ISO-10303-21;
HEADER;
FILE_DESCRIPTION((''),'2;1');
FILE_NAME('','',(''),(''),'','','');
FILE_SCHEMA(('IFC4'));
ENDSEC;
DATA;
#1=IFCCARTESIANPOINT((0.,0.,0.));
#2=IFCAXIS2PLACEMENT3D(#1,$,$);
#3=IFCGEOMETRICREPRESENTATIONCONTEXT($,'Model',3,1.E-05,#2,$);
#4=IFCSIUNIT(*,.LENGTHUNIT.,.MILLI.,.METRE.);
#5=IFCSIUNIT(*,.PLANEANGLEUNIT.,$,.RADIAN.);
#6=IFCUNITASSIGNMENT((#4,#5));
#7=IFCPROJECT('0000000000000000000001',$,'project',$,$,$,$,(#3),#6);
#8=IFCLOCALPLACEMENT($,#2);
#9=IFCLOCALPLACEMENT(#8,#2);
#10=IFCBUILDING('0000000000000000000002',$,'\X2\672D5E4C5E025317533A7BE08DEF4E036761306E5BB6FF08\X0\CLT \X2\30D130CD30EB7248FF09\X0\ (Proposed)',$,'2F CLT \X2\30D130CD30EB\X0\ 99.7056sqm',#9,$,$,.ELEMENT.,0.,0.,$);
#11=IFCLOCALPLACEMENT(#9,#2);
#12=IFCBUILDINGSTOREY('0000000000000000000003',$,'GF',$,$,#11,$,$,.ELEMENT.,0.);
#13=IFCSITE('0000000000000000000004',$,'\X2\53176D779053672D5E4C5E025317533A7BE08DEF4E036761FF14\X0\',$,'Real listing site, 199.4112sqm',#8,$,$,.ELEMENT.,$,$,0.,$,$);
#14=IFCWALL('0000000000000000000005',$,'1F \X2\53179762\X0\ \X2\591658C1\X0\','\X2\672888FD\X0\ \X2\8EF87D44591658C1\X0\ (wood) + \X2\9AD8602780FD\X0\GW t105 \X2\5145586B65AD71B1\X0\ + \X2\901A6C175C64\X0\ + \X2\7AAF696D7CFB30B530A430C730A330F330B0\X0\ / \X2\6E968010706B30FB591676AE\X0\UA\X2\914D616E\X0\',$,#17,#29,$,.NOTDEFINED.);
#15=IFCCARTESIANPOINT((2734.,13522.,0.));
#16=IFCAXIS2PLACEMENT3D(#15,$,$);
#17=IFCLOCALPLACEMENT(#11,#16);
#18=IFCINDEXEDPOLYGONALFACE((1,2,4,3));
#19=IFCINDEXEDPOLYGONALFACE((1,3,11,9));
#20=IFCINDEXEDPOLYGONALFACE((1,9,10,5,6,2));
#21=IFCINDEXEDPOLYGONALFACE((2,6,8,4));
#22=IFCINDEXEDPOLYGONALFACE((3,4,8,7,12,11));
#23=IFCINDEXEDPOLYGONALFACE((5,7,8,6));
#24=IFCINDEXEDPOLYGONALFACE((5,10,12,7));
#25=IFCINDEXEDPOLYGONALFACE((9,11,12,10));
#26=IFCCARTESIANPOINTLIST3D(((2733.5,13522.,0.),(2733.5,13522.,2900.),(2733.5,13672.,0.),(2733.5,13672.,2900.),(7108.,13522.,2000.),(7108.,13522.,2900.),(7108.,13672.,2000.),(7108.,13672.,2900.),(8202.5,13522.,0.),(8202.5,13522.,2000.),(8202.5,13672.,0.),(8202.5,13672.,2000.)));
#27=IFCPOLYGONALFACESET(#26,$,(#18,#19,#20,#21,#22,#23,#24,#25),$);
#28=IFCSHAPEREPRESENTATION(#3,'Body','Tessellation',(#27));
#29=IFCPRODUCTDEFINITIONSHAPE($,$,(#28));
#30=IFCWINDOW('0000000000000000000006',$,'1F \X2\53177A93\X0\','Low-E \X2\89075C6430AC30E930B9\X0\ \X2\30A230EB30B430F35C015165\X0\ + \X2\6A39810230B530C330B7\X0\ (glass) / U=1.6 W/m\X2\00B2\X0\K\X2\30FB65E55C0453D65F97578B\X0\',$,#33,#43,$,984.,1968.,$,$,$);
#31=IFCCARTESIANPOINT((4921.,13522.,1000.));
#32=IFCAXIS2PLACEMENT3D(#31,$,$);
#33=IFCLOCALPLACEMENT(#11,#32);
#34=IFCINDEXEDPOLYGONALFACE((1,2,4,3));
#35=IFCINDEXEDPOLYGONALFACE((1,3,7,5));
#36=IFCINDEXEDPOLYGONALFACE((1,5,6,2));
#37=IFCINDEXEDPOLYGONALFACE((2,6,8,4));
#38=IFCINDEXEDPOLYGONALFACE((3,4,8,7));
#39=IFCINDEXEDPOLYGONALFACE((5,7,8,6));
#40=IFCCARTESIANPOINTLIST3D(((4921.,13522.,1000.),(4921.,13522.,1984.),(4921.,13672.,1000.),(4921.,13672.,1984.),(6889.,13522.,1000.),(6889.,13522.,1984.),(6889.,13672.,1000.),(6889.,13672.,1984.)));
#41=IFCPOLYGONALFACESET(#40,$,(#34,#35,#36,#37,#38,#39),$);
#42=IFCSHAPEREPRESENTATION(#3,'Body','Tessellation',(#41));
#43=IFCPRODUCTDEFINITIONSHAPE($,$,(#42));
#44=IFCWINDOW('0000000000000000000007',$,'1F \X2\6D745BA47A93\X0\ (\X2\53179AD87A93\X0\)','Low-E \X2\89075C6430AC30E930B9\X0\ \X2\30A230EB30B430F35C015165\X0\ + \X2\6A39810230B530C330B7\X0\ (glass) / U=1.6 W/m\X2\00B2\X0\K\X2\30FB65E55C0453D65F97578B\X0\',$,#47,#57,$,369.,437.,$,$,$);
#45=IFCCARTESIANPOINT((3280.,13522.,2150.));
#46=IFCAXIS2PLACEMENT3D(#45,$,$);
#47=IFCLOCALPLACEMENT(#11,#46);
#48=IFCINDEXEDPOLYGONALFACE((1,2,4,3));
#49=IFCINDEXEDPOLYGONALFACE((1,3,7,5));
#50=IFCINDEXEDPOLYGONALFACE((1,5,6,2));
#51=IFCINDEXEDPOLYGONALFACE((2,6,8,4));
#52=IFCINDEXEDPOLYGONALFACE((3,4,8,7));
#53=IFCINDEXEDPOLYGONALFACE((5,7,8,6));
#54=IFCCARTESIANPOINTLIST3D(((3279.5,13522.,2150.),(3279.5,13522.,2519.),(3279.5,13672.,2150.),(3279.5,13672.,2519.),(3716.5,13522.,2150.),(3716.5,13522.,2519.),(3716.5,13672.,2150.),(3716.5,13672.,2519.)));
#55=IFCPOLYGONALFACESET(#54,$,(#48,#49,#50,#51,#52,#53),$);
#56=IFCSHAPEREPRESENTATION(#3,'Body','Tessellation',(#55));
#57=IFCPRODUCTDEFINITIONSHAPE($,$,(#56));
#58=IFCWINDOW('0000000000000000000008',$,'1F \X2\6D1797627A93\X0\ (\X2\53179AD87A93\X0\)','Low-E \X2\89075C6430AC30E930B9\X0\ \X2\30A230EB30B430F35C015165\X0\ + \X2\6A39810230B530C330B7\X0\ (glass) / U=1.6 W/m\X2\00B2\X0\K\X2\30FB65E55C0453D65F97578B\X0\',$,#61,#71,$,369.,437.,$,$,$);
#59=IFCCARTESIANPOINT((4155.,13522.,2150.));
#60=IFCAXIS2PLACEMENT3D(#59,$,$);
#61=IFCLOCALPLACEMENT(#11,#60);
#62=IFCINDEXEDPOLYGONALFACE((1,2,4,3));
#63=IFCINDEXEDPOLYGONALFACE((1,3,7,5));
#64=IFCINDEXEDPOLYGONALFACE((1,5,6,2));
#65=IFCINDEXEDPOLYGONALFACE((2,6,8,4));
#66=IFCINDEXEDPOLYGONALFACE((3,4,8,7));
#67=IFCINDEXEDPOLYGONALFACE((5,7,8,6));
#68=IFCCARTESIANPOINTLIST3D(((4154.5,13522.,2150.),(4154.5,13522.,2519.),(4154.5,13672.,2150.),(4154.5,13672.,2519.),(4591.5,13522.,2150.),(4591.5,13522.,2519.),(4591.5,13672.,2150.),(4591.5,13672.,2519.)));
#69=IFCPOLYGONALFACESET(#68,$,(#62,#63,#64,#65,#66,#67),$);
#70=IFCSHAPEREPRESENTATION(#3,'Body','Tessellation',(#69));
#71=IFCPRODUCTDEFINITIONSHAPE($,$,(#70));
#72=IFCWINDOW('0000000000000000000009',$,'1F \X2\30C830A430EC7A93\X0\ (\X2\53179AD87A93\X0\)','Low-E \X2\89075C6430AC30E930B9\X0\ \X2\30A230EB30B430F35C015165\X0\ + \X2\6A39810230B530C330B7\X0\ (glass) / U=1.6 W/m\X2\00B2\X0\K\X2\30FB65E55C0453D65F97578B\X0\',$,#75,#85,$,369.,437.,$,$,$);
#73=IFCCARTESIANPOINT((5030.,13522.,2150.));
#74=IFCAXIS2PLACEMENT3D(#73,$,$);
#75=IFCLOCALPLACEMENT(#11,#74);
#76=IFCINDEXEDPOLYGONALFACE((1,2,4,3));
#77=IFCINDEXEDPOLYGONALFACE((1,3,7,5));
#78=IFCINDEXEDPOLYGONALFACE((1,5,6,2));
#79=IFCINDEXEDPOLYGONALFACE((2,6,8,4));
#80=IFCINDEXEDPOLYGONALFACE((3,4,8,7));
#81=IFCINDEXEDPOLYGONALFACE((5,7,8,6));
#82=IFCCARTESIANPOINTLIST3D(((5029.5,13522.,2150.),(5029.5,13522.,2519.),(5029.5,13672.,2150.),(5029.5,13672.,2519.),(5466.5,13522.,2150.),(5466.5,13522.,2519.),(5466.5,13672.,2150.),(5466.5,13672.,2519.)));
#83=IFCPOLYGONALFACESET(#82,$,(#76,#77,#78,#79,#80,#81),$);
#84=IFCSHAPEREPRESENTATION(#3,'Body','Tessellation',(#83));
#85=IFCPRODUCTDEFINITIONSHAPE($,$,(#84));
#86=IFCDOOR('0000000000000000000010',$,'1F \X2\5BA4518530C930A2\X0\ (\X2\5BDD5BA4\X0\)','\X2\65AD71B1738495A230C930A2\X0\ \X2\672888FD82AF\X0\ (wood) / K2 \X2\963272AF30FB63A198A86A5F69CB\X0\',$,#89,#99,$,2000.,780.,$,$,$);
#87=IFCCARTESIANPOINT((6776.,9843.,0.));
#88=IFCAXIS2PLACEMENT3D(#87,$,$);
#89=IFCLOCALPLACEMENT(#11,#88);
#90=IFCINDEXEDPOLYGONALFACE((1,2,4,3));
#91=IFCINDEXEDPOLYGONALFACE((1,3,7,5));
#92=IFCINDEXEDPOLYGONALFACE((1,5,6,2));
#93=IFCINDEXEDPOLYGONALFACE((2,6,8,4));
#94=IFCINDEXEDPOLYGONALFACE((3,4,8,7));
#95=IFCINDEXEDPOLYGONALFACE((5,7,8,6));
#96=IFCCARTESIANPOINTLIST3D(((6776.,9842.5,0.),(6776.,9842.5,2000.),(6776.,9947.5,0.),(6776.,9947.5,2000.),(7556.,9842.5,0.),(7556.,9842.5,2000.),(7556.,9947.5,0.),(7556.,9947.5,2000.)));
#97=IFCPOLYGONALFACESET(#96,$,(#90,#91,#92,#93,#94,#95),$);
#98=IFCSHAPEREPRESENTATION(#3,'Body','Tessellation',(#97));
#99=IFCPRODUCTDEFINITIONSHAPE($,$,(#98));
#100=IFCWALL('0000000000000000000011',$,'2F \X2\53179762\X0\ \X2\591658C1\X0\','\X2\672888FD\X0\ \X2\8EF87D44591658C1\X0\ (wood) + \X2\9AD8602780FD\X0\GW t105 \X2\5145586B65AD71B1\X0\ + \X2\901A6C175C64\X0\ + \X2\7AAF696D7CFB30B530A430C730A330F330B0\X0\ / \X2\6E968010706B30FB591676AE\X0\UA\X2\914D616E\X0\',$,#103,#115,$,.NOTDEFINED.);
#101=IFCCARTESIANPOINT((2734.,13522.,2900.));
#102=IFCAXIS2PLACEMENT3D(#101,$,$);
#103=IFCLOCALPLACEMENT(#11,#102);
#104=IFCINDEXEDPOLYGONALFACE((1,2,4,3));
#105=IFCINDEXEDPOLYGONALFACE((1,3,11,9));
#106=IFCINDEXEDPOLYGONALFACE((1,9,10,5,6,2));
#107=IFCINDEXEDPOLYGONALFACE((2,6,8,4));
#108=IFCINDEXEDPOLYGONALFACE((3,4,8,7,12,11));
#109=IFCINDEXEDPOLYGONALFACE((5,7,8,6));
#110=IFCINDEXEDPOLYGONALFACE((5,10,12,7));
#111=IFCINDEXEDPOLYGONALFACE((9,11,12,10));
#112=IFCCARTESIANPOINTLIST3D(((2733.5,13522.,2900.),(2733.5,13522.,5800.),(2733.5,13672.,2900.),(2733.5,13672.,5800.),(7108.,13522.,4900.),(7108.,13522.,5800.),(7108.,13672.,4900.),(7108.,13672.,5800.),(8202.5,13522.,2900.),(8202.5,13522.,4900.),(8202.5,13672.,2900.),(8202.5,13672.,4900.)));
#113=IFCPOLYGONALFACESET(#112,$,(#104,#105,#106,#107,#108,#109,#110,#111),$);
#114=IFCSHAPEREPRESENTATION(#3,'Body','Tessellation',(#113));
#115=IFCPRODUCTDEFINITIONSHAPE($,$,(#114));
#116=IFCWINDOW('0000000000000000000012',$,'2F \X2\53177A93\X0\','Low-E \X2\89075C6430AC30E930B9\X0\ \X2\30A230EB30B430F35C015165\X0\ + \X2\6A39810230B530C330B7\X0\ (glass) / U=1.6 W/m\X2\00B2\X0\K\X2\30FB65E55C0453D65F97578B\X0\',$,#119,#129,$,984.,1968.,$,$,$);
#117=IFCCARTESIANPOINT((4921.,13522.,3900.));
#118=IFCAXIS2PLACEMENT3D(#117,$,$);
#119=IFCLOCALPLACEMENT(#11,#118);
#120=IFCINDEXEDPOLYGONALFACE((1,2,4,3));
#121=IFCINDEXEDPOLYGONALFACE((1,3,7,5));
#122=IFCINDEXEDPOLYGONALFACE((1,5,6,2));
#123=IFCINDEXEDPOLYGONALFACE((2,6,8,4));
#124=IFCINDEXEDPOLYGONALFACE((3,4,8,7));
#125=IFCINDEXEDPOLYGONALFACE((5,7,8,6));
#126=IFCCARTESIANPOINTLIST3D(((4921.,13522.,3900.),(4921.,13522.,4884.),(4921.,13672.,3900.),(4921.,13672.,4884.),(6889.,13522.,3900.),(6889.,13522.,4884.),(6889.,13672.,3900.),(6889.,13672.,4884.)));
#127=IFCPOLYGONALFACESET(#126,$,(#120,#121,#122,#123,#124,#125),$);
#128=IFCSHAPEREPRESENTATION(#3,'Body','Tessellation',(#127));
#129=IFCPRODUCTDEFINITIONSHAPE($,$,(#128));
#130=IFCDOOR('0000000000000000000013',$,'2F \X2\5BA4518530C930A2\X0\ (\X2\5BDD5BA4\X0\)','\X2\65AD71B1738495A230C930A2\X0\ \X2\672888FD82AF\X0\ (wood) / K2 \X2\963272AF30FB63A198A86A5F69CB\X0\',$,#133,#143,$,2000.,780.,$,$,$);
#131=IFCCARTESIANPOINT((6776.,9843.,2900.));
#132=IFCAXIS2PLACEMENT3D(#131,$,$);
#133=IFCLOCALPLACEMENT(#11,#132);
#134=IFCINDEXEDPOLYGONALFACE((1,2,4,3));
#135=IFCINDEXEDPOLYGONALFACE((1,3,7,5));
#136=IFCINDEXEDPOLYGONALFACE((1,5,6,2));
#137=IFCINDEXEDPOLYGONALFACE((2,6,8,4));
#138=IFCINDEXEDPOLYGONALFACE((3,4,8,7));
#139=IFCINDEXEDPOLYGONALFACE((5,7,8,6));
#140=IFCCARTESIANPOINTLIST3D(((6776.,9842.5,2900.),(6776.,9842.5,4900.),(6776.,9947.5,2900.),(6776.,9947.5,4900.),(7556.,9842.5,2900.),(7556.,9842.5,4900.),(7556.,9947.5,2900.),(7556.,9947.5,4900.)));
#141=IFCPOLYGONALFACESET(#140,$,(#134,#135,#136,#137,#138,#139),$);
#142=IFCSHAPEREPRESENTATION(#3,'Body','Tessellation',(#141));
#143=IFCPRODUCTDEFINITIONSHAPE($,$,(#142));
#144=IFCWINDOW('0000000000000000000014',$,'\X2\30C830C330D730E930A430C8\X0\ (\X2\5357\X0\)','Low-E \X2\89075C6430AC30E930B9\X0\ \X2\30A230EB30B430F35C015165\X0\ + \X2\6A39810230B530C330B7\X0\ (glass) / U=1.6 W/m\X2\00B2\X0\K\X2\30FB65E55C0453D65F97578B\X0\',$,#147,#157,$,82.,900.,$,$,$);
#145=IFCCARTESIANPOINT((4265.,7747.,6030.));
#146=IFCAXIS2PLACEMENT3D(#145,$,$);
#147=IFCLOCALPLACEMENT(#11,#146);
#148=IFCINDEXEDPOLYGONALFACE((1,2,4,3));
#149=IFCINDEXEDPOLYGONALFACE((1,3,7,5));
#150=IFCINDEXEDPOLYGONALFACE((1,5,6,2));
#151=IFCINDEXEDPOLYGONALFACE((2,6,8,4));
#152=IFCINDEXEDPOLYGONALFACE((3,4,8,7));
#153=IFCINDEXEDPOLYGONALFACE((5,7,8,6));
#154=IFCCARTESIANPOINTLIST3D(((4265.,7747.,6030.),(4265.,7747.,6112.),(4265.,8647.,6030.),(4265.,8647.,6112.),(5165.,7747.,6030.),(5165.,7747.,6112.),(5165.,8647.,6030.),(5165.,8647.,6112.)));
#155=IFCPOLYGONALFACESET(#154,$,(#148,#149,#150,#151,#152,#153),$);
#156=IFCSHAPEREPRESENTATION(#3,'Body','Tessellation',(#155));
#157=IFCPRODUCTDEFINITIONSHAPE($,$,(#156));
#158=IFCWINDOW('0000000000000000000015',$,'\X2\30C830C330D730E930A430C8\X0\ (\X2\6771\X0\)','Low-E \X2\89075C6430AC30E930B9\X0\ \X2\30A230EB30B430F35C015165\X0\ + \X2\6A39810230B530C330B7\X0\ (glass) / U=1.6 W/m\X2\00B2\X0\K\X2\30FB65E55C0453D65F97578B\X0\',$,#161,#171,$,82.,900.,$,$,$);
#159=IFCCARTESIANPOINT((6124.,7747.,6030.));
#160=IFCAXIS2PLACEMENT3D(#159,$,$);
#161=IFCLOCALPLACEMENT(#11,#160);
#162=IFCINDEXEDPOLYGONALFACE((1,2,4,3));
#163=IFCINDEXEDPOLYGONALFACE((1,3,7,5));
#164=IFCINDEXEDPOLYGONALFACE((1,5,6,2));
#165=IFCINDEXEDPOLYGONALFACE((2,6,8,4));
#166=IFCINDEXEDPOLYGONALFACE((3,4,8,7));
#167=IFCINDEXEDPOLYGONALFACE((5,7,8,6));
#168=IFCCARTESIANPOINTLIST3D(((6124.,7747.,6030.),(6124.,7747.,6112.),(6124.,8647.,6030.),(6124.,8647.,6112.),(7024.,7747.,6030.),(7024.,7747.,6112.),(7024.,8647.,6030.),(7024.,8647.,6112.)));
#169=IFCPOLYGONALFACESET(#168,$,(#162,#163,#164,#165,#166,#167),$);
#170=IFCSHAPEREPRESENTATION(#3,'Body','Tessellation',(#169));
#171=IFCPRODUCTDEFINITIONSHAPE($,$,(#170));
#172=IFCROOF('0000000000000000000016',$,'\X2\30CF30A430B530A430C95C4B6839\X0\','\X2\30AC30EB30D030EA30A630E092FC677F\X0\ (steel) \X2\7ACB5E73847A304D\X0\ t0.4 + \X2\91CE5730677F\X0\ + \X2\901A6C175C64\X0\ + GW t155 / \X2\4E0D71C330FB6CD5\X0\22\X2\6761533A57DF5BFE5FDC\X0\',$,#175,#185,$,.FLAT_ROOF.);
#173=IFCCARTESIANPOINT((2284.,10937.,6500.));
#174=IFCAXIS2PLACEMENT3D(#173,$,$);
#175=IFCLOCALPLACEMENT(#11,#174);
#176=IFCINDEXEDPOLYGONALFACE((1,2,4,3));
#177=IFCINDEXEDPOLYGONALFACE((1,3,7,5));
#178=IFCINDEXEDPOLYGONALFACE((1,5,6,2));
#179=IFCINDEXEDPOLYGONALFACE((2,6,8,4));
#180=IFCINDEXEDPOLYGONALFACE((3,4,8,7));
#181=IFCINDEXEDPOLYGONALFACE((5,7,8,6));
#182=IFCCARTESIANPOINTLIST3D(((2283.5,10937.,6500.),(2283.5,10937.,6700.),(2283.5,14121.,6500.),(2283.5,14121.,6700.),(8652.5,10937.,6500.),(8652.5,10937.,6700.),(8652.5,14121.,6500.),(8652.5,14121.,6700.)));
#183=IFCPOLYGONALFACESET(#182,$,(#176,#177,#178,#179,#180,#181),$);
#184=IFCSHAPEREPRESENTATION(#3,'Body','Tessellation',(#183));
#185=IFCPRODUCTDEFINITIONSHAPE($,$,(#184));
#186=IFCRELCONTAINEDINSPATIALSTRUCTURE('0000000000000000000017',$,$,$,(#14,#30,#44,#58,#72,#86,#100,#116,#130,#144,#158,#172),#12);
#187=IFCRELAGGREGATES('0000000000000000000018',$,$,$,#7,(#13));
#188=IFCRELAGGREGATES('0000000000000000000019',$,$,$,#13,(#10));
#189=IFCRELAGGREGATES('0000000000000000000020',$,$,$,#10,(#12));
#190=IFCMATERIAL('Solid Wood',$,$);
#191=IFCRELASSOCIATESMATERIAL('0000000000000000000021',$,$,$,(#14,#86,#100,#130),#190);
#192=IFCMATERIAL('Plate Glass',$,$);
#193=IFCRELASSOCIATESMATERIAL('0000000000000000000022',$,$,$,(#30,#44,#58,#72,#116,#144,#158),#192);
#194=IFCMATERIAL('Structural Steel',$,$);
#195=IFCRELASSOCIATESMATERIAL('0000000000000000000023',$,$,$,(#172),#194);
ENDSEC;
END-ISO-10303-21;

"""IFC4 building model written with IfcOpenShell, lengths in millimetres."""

from ifc_helpers import new_model, si_unit, frame, frame_2d, origin, place, context, project, spatial, rectangle, extrude, material, element, fill, save


model = new_model("IFC4")

# Units and contexts
model_context = context("Model", 3, precision=1e-05, world=origin())
ifc_project = project(units=[si_unit("LENGTHUNIT", "METRE", prefix="MILLI"), si_unit("PLANEANGLEUNIT", "RADIAN")], contexts=[model_context])

# Site, building, storey
site_placement = place(None, origin())
site = spatial("IfcSite", under=ifc_project, at=site_placement, Name="北海道札幌市北区篠路七条４", ObjectType="Real listing site, 199.4112sqm", CompositionType="ELEMENT", RefElevation=0.0)
building_placement = place(site_placement, origin())
building = spatial("IfcBuilding", under=site, at=building_placement, Name="札幌市北区篠路七条の家（CLT パネル版） (Proposed)", ObjectType="2F CLT パネル 99.7056sqm", CompositionType="ELEMENT", ElevationOfRefHeight=0.0, ElevationOfTerrain=0.0)
storey_placement = place(building_placement, origin())
storey = spatial("IfcBuildingStorey", under=building, at=storey_placement, Name="GF", CompositionType="ELEMENT", Elevation=0.0)

# Wall, openings, windows
ifc_material_1 = material(Name="Solid Wood")
wall_1_placement = place(storey_placement, frame((2734.0, 13522.0, 0.0)))
wall_1 = element("IfcWall", 1, at=wall_1_placement, inside=storey, material=ifc_material_1, Name="1F 北面 外壁", Description="木製 軸組外壁 (wood) + 高性能GW t105 充填断熱 + 通気層 + 窯業系サイディング / 準耐火・外皮UA配慮", PredefinedType="NOTDEFINED", context=model_context, shape_type="SweptSolid", body=[
    extrude(rectangle(XDim=5469.0, YDim=150.0, at=frame_2d((2734.0, 75.0))), frame((2734.0, 13522.0, 0.0)), (0.0, 0.0, 1.0), 2900.0),
])
opening_1_placement = place(storey_placement, frame((4921.0, 13522.0, 1000.0)))
opening_1 = element("IfcOpeningElement", 2, at=opening_1_placement, cuts=wall_1, PredefinedType="NOTDEFINED", context=model_context, shape_type="SweptSolid", body=[
    extrude(rectangle(XDim=1968.0, YDim=150.0, at=frame_2d((984.0, 75.0))), frame((4921.0, 13522.0, 1000.0)), (0.0, 0.0, 1.0), 984.0),
])
opening_2_placement = place(storey_placement, frame((3280.0, 13522.0, 2150.0)))
opening_2 = element("IfcOpeningElement", 3, at=opening_2_placement, cuts=wall_1, PredefinedType="NOTDEFINED", context=model_context, shape_type="SweptSolid", body=[
    extrude(rectangle(XDim=437.0, YDim=150.0, at=frame_2d((218.0, 75.0))), frame((3280.0, 13522.0, 2150.0)), (0.0, 0.0, 1.0), 369.0),
])
opening_3_placement = place(storey_placement, frame((4155.0, 13522.0, 2150.0)))
opening_3 = element("IfcOpeningElement", 4, at=opening_3_placement, cuts=wall_1, PredefinedType="NOTDEFINED", context=model_context, shape_type="SweptSolid", body=[
    extrude(rectangle(XDim=437.0, YDim=150.0, at=frame_2d((218.0, 75.0))), frame((4155.0, 13522.0, 2150.0)), (0.0, 0.0, 1.0), 369.0),
])
opening_4_placement = place(storey_placement, frame((5030.0, 13522.0, 2150.0)))
opening_4 = element("IfcOpeningElement", 5, at=opening_4_placement, cuts=wall_1, PredefinedType="NOTDEFINED", context=model_context, shape_type="SweptSolid", body=[
    extrude(rectangle(XDim=437.0, YDim=150.0, at=frame_2d((218.0, 75.0))), frame((5030.0, 13522.0, 2150.0)), (0.0, 0.0, 1.0), 369.0),
])
ifc_material_2 = material(Name="Plate Glass")
window_1_placement = place(storey_placement, frame((4921.0, 13522.0, 1000.0)))
window_1 = element("IfcWindow", 6, at=window_1_placement, inside=storey, material=ifc_material_2, Name="1F 北窓", Description="Low-E 複層ガラス アルゴン封入 + 樹脂サッシ (glass) / U=1.6 W/m²K・日射取得型", OverallHeight=984.0, OverallWidth=1968.0, context=model_context, shape_type="SweptSolid", body=[
    extrude(rectangle(XDim=1968.0, YDim=150.0, at=frame_2d((984.0, 75.0))), frame((4921.0, 13522.0, 1000.0)), (0.0, 0.0, 1.0), 984.0),
])
fill(opening_1, window_1)
window_2_placement = place(storey_placement, frame((3280.0, 13522.0, 2150.0)))
window_2 = element("IfcWindow", 7, at=window_2_placement, inside=storey, material=ifc_material_2, Name="1F 浴室窓 (北高窓)", Description="Low-E 複層ガラス アルゴン封入 + 樹脂サッシ (glass) / U=1.6 W/m²K・日射取得型", OverallHeight=369.0, OverallWidth=437.0, context=model_context, shape_type="SweptSolid", body=[
    extrude(rectangle(XDim=437.0, YDim=150.0, at=frame_2d((218.0, 75.0))), frame((3280.0, 13522.0, 2150.0)), (0.0, 0.0, 1.0), 369.0),
])
fill(opening_2, window_2)
window_3_placement = place(storey_placement, frame((4155.0, 13522.0, 2150.0)))
window_3 = element("IfcWindow", 8, at=window_3_placement, inside=storey, material=ifc_material_2, Name="1F 洗面窓 (北高窓)", Description="Low-E 複層ガラス アルゴン封入 + 樹脂サッシ (glass) / U=1.6 W/m²K・日射取得型", OverallHeight=369.0, OverallWidth=437.0, context=model_context, shape_type="SweptSolid", body=[
    extrude(rectangle(XDim=437.0, YDim=150.0, at=frame_2d((218.0, 75.0))), frame((4155.0, 13522.0, 2150.0)), (0.0, 0.0, 1.0), 369.0),
])
fill(opening_3, window_3)
window_4_placement = place(storey_placement, frame((5030.0, 13522.0, 2150.0)))
window_4 = element("IfcWindow", 9, at=window_4_placement, inside=storey, material=ifc_material_2, Name="1F トイレ窓 (北高窓)", Description="Low-E 複層ガラス アルゴン封入 + 樹脂サッシ (glass) / U=1.6 W/m²K・日射取得型", OverallHeight=369.0, OverallWidth=437.0, context=model_context, shape_type="SweptSolid", body=[
    extrude(rectangle(XDim=437.0, YDim=150.0, at=frame_2d((218.0, 75.0))), frame((5030.0, 13522.0, 2150.0)), (0.0, 0.0, 1.0), 369.0),
])
fill(opening_4, window_4)

# Door
door_1_placement = place(storey_placement, frame((6776.0, 9843.0, 0.0)))
element("IfcDoor", 10, at=door_1_placement, inside=storey, material=ifc_material_1, Name="1F 室内ドア (寝室)", Description="断熱玄関ドア 木製芯 (wood) / K2 防犯・採風機構", OverallHeight=2000.0, OverallWidth=780.0, context=model_context, shape_type="SweptSolid", body=[
    extrude(rectangle(XDim=780.0, YDim=105.0, at=frame_2d((390.0, 52.0))), frame((6776.0, 9843.0, 0.0)), (0.0, 0.0, 1.0), 2000.0),
])

# Wall, opening, window
wall_2_placement = place(storey_placement, frame((2734.0, 13522.0, 2900.0)))
wall_2 = element("IfcWall", 11, at=wall_2_placement, inside=storey, material=ifc_material_1, Name="2F 北面 外壁", Description="木製 軸組外壁 (wood) + 高性能GW t105 充填断熱 + 通気層 + 窯業系サイディング / 準耐火・外皮UA配慮", PredefinedType="NOTDEFINED", context=model_context, shape_type="SweptSolid", body=[
    extrude(rectangle(XDim=5469.0, YDim=150.0, at=frame_2d((2734.0, 75.0))), frame((2734.0, 13522.0, 2900.0)), (0.0, 0.0, 1.0), 2900.0),
])
opening_5_placement = place(storey_placement, frame((4921.0, 13522.0, 3900.0)))
opening_5 = element("IfcOpeningElement", 12, at=opening_5_placement, cuts=wall_2, PredefinedType="NOTDEFINED", context=model_context, shape_type="SweptSolid", body=[
    extrude(rectangle(XDim=1968.0, YDim=150.0, at=frame_2d((984.0, 75.0))), frame((4921.0, 13522.0, 3900.0)), (0.0, 0.0, 1.0), 984.0),
])
window_5_placement = place(storey_placement, frame((4921.0, 13522.0, 3900.0)))
window_5 = element("IfcWindow", 13, at=window_5_placement, inside=storey, material=ifc_material_2, Name="2F 北窓", Description="Low-E 複層ガラス アルゴン封入 + 樹脂サッシ (glass) / U=1.6 W/m²K・日射取得型", OverallHeight=984.0, OverallWidth=1968.0, context=model_context, shape_type="SweptSolid", body=[
    extrude(rectangle(XDim=1968.0, YDim=150.0, at=frame_2d((984.0, 75.0))), frame((4921.0, 13522.0, 3900.0)), (0.0, 0.0, 1.0), 984.0),
])
fill(opening_5, window_5)

# Door
door_2_placement = place(storey_placement, frame((6776.0, 9843.0, 2900.0)))
element("IfcDoor", 14, at=door_2_placement, inside=storey, material=ifc_material_1, Name="2F 室内ドア (寝室)", Description="断熱玄関ドア 木製芯 (wood) / K2 防犯・採風機構", OverallHeight=2000.0, OverallWidth=780.0, context=model_context, shape_type="SweptSolid", body=[
    extrude(rectangle(XDim=780.0, YDim=105.0, at=frame_2d((390.0, 52.0))), frame((6776.0, 9843.0, 2900.0)), (0.0, 0.0, 1.0), 2000.0),
])

# Windows
window_6_placement = place(storey_placement, frame((4265.0, 7747.0, 6030.0)))
element("IfcWindow", 15, at=window_6_placement, inside=storey, material=ifc_material_2, Name="トップライト (南)", Description="Low-E 複層ガラス アルゴン封入 + 樹脂サッシ (glass) / U=1.6 W/m²K・日射取得型", OverallHeight=82.0, OverallWidth=900.0, context=model_context, shape_type="SweptSolid", body=[
    extrude(rectangle(XDim=900.0, YDim=900.0, at=frame_2d((450.0, 450.0))), frame((4265.0, 7747.0, 6030.0)), (0.0, 0.0, 1.0), 82.0),
])
window_7_placement = place(storey_placement, frame((6124.0, 7747.0, 6030.0)))
element("IfcWindow", 16, at=window_7_placement, inside=storey, material=ifc_material_2, Name="トップライト (東)", Description="Low-E 複層ガラス アルゴン封入 + 樹脂サッシ (glass) / U=1.6 W/m²K・日射取得型", OverallHeight=82.0, OverallWidth=900.0, context=model_context, shape_type="SweptSolid", body=[
    extrude(rectangle(XDim=900.0, YDim=900.0, at=frame_2d((450.0, 450.0))), frame((6124.0, 7747.0, 6030.0)), (0.0, 0.0, 1.0), 82.0),
])

# Roof
ifc_material_3 = material(Name="Structural Steel")
roof_placement = place(storey_placement, frame((2284.0, 10937.0, 6500.0)))
element("IfcRoof", 17, at=roof_placement, inside=storey, material=ifc_material_3, Name="ハイサイド屋根", Description="ガルバリウム鋼板 (steel) 立平葺き t0.4 + 野地板 + 通気層 + GW t155 / 不燃・法22条区域対応", PredefinedType="FLAT_ROOF", context=model_context, shape_type="SweptSolid", body=[
    extrude(rectangle(XDim=6369.0, YDim=3184.0, at=frame_2d((3184.0, 1592.0))), frame((2284.0, 10937.0, 6500.0)), (0.0, 0.0, 1.0), 200.0),
])

save(model, "model.ifc")
